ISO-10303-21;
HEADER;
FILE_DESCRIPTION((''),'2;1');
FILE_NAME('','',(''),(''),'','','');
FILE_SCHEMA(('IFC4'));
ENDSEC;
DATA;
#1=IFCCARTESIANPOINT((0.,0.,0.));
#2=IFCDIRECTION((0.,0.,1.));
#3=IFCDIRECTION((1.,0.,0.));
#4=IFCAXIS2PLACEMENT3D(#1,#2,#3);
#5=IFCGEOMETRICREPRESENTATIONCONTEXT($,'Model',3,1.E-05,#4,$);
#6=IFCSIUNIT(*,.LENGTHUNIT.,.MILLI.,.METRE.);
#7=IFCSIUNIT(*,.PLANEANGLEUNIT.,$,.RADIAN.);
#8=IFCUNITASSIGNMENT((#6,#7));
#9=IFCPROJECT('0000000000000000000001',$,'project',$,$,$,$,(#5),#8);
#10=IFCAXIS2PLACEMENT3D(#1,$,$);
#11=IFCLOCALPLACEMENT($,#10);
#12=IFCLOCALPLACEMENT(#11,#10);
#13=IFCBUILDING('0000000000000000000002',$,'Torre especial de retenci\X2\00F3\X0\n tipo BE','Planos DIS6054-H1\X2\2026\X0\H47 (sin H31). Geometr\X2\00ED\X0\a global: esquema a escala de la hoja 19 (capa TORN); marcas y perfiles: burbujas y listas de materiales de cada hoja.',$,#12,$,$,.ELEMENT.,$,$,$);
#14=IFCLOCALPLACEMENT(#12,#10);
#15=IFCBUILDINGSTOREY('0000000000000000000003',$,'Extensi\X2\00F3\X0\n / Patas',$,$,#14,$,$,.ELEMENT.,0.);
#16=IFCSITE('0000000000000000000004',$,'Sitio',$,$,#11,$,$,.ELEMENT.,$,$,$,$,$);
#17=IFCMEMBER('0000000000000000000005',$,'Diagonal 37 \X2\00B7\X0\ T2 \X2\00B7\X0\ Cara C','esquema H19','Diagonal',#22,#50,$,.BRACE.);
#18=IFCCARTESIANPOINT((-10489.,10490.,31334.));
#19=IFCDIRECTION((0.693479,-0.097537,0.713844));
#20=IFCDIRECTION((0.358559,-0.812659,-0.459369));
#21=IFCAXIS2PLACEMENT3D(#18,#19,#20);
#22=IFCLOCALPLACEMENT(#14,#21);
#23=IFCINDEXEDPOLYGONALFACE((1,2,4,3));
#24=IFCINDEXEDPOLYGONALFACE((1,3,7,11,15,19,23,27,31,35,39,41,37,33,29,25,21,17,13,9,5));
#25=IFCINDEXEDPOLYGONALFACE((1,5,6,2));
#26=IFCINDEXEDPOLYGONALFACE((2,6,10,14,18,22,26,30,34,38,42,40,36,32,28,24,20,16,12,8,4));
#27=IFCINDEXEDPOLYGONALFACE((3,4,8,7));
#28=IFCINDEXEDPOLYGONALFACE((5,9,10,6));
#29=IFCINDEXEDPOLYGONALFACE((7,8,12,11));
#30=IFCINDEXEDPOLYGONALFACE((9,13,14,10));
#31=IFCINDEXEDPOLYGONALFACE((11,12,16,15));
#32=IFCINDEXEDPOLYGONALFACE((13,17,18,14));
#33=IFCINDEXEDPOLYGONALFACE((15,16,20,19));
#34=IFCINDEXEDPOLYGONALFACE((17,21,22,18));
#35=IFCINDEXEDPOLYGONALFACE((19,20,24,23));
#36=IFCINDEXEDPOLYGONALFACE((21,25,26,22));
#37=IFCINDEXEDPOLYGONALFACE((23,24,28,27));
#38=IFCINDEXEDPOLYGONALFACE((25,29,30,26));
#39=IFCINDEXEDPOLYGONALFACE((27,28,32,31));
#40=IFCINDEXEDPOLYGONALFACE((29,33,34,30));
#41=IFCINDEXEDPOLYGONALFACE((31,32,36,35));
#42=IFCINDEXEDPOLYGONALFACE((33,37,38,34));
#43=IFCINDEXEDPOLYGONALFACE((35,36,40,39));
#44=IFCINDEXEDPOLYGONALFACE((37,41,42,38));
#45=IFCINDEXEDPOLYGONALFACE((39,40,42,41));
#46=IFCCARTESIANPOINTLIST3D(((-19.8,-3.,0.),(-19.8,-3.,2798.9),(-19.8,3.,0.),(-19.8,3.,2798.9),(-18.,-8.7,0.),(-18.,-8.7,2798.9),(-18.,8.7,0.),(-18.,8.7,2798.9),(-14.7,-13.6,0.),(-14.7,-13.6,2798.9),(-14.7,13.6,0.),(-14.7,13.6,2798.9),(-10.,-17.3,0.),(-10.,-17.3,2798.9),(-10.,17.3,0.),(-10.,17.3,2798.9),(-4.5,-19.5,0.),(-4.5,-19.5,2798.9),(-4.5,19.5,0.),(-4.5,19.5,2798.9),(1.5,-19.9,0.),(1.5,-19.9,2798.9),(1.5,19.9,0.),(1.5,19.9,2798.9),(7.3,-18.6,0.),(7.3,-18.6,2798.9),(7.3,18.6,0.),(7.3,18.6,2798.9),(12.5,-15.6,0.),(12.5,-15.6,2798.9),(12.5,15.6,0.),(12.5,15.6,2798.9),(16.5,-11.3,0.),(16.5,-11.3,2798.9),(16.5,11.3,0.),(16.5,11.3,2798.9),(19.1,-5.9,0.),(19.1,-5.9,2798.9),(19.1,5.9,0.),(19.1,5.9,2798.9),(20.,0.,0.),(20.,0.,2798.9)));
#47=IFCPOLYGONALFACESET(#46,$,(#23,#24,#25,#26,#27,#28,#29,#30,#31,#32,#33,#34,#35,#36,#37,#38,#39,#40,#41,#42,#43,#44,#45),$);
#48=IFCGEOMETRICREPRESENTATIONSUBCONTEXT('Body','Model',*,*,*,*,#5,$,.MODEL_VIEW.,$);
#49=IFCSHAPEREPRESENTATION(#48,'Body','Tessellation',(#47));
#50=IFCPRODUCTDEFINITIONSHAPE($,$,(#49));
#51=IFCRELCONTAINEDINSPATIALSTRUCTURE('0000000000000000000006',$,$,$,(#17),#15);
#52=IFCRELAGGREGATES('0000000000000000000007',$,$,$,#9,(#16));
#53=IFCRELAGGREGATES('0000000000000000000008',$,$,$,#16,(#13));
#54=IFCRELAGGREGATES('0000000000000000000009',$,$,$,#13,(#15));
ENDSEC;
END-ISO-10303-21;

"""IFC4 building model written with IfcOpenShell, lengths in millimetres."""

from ifc_helpers import new_model, si_unit, frame, origin, origin_with_axes, place, context, subcontext, project, spatial, circle, extrude, element, save


model = new_model("IFC4")

# Units and contexts
model_context = context("Model", 3, precision=1e-05, world=origin_with_axes())
body_context = subcontext(model_context, "Body", "Model", "MODEL_VIEW")
ifc_project = project(units=[si_unit("LENGTHUNIT", "METRE", prefix="MILLI"), si_unit("PLANEANGLEUNIT", "RADIAN")], contexts=[model_context])

# Site, building, storey
site_placement = place(None, origin())
site = spatial("IfcSite", under=ifc_project, at=site_placement, Name="Sitio", CompositionType="ELEMENT")
building_placement = place(site_placement, origin())
building = spatial("IfcBuilding", under=site, at=building_placement, Name="Torre especial de retención tipo BE", Description="Planos DIS6054-H1…H47 (sin H31). Geometría global: esquema a escala de la hoja 19 (capa TORN); marcas y perfiles: burbujas y listas de materiales de cada hoja.", CompositionType="ELEMENT")
storey_placement = place(building_placement, origin())
storey = spatial("IfcBuildingStorey", under=building, at=storey_placement, Name="Extensión / Patas", CompositionType="ELEMENT", Elevation=0.0)

# Member
member_1_placement = place(storey_placement, frame((-10489.0, 10490.0, 31334.0), z_axis=(0.693479, -0.097537, 0.713844), x_axis=(0.358559, -0.812659, -0.459369)))
element("IfcMember", 1, at=member_1_placement, inside=storey, Name="Diagonal 37 · T2 · Cara C", Description="esquema H19", ObjectType="Diagonal", PredefinedType="BRACE", context=body_context, shape_type="SweptSolid", body=[
    extrude(circle(Radius=20.0), None, (0.0, 0.0, 1.0), 2798.9),
])

save(model, "model.ifc")
